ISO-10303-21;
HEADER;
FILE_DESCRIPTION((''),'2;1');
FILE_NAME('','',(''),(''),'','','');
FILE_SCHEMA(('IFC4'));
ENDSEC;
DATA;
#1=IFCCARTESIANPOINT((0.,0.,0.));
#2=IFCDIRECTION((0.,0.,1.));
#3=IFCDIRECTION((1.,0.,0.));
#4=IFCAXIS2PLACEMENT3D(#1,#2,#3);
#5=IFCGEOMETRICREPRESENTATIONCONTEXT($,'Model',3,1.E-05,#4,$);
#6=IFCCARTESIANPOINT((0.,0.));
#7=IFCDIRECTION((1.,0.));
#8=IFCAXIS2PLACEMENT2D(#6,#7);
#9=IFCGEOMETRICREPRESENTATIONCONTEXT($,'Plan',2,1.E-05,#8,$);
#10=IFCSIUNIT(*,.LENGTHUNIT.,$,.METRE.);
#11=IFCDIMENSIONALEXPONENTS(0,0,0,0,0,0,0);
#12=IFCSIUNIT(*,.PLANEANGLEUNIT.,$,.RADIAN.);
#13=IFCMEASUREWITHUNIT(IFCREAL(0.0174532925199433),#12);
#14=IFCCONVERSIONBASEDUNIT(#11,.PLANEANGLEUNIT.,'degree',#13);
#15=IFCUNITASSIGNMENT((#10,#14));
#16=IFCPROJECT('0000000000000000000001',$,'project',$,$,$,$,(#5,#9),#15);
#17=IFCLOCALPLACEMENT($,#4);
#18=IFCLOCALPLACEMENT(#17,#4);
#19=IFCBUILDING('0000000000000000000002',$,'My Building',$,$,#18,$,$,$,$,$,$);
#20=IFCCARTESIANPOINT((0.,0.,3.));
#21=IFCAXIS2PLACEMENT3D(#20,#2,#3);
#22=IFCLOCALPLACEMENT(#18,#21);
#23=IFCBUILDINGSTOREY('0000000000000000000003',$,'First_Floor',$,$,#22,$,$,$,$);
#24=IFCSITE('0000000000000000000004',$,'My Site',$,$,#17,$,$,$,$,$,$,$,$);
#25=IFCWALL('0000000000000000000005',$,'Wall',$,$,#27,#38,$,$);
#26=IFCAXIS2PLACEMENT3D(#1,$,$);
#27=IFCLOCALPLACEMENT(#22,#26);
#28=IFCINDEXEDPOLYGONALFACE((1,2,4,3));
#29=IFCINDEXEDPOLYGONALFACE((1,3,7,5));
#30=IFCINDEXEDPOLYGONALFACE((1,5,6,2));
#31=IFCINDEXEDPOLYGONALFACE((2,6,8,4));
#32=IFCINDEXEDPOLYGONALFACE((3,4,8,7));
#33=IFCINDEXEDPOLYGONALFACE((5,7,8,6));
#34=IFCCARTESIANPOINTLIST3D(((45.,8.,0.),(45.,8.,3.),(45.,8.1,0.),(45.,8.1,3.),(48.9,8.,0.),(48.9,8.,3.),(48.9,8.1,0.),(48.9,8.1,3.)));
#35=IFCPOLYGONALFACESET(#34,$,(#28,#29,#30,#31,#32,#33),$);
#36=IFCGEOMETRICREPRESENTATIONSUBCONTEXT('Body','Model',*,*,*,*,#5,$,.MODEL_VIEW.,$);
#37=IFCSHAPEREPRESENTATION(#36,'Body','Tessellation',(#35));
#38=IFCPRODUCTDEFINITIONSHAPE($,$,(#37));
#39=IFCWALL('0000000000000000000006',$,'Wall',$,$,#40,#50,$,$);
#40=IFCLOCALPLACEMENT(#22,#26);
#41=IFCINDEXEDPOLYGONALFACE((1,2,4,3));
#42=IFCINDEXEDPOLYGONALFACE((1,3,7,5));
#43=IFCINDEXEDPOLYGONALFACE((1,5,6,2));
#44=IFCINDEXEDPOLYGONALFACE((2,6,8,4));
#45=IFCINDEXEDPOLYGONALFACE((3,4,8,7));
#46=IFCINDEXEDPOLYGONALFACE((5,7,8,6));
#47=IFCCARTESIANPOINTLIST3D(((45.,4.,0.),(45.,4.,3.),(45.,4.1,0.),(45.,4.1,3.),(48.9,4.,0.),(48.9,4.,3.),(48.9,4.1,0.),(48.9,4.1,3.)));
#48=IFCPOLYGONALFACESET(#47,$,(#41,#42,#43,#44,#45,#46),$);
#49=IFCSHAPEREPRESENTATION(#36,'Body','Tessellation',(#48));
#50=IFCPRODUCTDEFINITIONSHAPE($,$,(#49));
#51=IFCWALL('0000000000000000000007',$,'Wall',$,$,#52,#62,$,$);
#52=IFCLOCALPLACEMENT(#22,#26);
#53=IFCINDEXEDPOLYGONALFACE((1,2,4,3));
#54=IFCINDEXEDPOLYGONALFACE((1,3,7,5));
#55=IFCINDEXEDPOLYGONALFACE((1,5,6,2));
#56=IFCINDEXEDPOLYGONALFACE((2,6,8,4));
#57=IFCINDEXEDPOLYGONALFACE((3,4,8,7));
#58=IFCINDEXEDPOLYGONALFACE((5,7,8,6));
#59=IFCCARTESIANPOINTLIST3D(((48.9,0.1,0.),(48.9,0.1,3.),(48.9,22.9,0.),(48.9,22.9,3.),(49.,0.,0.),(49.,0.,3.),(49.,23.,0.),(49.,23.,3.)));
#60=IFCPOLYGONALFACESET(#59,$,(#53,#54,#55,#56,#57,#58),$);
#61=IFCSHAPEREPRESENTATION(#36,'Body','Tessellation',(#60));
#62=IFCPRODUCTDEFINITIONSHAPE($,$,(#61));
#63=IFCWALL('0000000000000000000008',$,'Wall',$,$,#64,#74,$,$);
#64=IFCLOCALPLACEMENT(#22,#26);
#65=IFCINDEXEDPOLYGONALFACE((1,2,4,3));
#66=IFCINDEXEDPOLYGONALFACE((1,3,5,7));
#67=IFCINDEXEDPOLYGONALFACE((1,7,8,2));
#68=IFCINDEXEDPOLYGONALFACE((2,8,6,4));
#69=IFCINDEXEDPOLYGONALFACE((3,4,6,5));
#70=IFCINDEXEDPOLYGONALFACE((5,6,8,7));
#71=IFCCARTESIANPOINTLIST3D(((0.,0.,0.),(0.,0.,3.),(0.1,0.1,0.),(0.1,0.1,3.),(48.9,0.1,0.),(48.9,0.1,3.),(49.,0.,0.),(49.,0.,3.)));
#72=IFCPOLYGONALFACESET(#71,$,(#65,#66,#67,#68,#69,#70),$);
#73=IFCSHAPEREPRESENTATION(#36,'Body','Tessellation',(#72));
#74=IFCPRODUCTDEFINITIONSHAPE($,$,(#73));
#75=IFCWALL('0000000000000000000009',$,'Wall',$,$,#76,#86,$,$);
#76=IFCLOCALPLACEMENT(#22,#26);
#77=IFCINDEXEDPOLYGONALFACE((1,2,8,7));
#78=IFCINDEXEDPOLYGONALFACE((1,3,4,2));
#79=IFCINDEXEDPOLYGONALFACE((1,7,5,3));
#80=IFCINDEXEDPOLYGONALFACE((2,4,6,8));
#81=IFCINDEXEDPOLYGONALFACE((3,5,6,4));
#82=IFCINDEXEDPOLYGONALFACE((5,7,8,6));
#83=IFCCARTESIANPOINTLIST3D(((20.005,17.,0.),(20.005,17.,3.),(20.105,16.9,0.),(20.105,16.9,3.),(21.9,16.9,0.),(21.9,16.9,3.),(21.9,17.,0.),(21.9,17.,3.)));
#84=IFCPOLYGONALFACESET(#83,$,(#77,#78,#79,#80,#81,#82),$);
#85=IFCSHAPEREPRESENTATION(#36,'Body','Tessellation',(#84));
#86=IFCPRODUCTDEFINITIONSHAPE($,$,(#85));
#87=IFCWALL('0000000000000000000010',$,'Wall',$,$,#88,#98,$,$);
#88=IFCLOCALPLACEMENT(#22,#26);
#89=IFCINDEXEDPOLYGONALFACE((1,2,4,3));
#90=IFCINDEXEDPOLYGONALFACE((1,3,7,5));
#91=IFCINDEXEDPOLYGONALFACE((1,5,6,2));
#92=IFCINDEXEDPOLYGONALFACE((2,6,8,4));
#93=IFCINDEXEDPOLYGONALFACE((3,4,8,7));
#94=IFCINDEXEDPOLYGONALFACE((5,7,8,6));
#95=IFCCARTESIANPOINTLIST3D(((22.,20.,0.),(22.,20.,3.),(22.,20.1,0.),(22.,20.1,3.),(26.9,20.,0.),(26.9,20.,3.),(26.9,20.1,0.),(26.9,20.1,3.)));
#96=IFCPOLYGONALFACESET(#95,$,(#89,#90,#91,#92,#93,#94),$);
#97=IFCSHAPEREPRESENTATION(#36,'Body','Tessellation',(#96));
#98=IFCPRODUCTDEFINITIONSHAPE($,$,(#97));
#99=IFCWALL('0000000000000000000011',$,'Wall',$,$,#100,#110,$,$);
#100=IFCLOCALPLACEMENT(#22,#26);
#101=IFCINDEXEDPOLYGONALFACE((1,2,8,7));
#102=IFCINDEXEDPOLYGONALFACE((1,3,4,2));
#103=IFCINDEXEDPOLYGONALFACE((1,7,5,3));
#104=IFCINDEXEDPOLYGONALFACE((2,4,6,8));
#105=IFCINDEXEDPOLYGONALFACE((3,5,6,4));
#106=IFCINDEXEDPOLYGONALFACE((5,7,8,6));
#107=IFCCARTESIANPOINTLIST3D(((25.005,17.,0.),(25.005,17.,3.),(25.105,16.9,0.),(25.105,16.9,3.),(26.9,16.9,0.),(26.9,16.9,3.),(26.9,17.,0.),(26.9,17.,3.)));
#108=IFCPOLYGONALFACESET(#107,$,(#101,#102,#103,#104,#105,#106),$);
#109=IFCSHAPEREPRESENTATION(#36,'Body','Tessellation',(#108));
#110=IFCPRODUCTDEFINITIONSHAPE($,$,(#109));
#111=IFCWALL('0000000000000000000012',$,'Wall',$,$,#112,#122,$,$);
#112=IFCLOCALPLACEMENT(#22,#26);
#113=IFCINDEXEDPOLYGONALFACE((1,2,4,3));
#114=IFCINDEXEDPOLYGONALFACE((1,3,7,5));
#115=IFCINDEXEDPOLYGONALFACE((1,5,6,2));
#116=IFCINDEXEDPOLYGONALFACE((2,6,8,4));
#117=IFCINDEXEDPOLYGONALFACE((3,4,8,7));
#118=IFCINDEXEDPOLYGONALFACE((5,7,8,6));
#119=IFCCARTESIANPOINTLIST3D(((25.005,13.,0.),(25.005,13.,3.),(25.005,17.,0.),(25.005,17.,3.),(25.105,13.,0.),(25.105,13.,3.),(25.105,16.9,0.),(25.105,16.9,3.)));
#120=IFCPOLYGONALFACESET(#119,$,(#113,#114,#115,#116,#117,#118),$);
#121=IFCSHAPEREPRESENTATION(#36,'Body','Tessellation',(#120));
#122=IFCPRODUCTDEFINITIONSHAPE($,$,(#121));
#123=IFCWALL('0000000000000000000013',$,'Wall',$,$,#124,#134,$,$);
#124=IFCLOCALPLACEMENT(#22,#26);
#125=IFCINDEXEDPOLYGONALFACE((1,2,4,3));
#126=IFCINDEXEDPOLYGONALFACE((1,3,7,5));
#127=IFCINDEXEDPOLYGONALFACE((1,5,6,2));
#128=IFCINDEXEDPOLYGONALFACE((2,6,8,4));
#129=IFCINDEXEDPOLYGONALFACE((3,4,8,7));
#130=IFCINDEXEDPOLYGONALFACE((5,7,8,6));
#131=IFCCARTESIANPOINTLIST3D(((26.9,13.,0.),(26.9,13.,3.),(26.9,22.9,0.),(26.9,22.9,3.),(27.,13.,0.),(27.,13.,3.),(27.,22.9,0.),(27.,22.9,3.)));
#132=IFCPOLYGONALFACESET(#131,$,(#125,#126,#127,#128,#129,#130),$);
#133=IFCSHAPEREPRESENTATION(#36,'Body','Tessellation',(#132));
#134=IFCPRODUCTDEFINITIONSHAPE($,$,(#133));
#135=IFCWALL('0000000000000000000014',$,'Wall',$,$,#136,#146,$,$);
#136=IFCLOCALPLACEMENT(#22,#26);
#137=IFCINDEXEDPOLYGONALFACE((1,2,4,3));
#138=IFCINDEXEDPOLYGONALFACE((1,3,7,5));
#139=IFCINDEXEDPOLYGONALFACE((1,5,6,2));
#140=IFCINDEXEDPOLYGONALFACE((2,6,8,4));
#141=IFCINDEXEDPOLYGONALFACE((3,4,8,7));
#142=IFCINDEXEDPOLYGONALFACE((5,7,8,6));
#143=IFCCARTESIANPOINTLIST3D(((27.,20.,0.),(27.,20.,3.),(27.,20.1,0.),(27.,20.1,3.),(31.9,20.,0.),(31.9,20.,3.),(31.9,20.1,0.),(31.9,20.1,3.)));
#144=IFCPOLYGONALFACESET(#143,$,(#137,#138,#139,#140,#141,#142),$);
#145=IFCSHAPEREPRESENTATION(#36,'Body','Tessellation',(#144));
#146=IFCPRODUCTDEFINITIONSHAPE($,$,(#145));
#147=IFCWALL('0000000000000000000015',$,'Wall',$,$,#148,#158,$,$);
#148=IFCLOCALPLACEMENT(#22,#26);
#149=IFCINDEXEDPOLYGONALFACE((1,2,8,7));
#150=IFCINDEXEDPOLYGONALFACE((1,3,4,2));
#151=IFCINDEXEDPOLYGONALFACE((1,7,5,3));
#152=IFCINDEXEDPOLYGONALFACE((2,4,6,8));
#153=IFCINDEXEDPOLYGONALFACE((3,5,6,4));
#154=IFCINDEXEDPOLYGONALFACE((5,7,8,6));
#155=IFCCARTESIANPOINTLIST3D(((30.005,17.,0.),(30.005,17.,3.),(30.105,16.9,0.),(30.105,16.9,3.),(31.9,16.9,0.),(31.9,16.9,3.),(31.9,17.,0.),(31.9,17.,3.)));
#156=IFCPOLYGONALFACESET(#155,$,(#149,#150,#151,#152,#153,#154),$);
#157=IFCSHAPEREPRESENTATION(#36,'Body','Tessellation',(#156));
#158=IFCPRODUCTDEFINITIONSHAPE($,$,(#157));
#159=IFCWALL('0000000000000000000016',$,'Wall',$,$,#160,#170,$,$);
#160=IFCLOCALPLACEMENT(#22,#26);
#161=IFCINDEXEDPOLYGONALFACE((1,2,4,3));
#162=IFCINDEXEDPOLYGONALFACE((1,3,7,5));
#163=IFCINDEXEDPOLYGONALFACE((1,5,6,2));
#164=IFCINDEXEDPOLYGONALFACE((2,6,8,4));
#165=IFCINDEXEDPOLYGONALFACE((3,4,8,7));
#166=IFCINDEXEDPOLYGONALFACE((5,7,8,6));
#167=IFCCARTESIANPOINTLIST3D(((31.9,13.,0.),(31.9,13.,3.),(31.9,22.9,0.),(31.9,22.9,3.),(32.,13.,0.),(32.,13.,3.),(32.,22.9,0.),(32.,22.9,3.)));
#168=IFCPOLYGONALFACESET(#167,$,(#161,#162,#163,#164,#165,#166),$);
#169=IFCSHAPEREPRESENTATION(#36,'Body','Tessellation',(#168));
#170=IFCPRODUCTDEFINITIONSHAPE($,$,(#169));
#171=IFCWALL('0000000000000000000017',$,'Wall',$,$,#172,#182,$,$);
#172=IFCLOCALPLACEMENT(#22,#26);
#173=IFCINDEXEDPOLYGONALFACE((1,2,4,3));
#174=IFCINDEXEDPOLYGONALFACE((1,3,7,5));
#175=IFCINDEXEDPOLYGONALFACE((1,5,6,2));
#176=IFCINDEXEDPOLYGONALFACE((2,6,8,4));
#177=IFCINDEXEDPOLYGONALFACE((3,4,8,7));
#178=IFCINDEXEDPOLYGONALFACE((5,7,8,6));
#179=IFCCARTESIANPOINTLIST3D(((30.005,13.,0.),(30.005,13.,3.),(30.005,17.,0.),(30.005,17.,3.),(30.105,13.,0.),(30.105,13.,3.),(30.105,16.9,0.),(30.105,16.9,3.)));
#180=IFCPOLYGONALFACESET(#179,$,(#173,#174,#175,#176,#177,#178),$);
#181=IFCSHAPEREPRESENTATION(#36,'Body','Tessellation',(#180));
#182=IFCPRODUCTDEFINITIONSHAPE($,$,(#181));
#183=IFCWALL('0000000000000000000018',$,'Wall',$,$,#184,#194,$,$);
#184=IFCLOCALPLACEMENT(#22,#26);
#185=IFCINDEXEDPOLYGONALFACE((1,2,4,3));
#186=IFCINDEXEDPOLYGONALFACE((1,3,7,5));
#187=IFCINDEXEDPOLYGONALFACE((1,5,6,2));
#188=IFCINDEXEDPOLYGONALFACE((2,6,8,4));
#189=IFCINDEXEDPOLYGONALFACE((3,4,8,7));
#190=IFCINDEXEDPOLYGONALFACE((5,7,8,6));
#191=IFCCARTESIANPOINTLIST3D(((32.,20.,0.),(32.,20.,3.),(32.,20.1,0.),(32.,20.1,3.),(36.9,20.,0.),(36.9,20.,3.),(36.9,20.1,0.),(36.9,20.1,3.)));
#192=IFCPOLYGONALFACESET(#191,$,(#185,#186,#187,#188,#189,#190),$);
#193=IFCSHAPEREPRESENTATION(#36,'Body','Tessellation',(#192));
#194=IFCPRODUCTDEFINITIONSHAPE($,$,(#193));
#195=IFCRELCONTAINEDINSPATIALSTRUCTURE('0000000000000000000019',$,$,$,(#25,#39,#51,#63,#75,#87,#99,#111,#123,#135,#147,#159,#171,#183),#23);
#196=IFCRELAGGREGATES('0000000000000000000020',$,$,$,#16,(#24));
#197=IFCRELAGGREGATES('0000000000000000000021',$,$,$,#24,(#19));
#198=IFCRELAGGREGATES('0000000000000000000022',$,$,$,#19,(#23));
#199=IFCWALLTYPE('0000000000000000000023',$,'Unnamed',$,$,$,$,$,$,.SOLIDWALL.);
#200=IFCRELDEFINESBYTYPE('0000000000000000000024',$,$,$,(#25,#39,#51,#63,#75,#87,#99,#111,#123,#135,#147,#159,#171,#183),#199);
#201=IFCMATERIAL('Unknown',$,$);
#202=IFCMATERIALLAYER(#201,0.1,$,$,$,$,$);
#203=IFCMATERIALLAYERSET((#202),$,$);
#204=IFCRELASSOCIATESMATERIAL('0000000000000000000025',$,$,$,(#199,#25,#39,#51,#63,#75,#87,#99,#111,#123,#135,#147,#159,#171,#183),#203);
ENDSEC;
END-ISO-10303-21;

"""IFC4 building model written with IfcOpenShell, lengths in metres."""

from ifc_helpers import new_model, entity, si_unit, converted_unit, frame, origin_with_axes, origin_2d_with_axis, place, context, subcontext, project, spatial, line, indexed_curve, outline, extrude, material, layer, layer_set, layer_usage, type_object, element, save


model = new_model("IFC4")

# Units and contexts
model_context = context("Model", 3, precision=1e-05, world=origin_with_axes())
plan_context = context("Plan", 2, precision=1e-05, world=origin_2d_with_axis())
body_context = subcontext(model_context, "Body", "Model", "MODEL_VIEW")
ifc_project = project(units=[si_unit("LENGTHUNIT", "METRE"), converted_unit("PLANEANGLEUNIT", "degree", entity("IfcReal", 0.0174532925199433), si_unit("PLANEANGLEUNIT", "RADIAN"), dimensions=[0, 0, 0, 0, 0, 0, 0])], contexts=[model_context, plan_context])

# Site, building, storey
site_placement = place(None, origin_with_axes())
site = spatial("IfcSite", under=ifc_project, at=site_placement, Name="My Site")
building_placement = place(site_placement, origin_with_axes())
building = spatial("IfcBuilding", under=site, at=building_placement, Name="My Building")
storey_placement = place(building_placement, frame((0.0, 0.0, 3.0), z_axis=(0.0, 0.0, 1.0), x_axis=(1.0, 0.0, 0.0)))
storey = spatial("IfcBuildingStorey", under=building, at=storey_placement, Name="First_Floor")

# Walls
ifc_material = material(Name="Unknown")
ifc_layer = layer(ifc_material, 0.1)
ifc_layer_set = layer_set([ifc_layer])
wall_type = type_object("IfcWallType", Name="Unnamed", PredefinedType="SOLIDWALL", material=ifc_layer_set)
ifc_layer_usage_1 = layer_usage(ifc_layer_set, "AXIS2", "POSITIVE", 0.0)
wall_1_placement = place(storey_placement, frame((45.0, 8.0, 0.0), z_axis=(0.0, 0.0, 1.0), x_axis=(1.0, 0.0, 0.0)))
element("IfcWall", 1, at=wall_1_placement, inside=storey, type_object=wall_type, material=ifc_layer_usage_1, Name="Wall", context=body_context, shape_type="SweptSolid", body=[
    extrude(outline(indexed_curve([(0.0, 0.0), (0.0, 0.1), (3.9, 0.1), (3.9, 0.0)], segments=[line(1, 2, 3, 4, 1)])), origin_with_axes(), (0.0, 0.0, 1.0), 3.0),
])
ifc_layer_usage_2 = layer_usage(ifc_layer_set, "AXIS2", "POSITIVE", 0.0)
wall_2_placement = place(storey_placement, frame((45.0, 4.0, 0.0), z_axis=(0.0, 0.0, 1.0), x_axis=(1.0, 0.0, 0.0)))
element("IfcWall", 2, at=wall_2_placement, inside=storey, type_object=wall_type, material=ifc_layer_usage_2, Name="Wall", context=body_context, shape_type="SweptSolid", body=[
    extrude(outline(indexed_curve([(0.0, 0.0), (0.0, 0.1), (3.9, 0.1), (3.9, 0.0)], segments=[line(1, 2, 3, 4, 1)])), origin_with_axes(), (0.0, 0.0, 1.0), 3.0),
])
ifc_layer_usage_3 = layer_usage(ifc_layer_set, "AXIS2", "POSITIVE", 0.0)
wall_3_placement = place(storey_placement, frame((48.9, 22.9, 0.0), z_axis=(0.0, 0.0, 1.0), x_axis=(0.0, -1.0, 0.0)))
element("IfcWall", 3, at=wall_3_placement, inside=storey, type_object=wall_type, material=ifc_layer_usage_3, Name="Wall", context=body_context, shape_type="SweptSolid", body=[
    extrude(outline(indexed_curve([(0.0, 0.0), (-0.1, 0.1), (22.9, 0.1), (22.8, 0.0)], segments=[line(1, 2, 3, 4, 1)])), origin_with_axes(), (0.0, 0.0, 1.0), 3.0),
])
ifc_layer_usage_4 = layer_usage(ifc_layer_set, "AXIS2", "POSITIVE", 0.0)
wall_4_placement = place(storey_placement, frame((48.9, 0.1, 0.0), z_axis=(0.0, 0.0, 1.0), x_axis=(-1.0, 0.0, 0.0)))
element("IfcWall", 4, at=wall_4_placement, inside=storey, type_object=wall_type, material=ifc_layer_usage_4, Name="Wall", context=body_context, shape_type="SweptSolid", body=[
    extrude(outline(indexed_curve([(0.0, 0.0), (-0.1, 0.1), (48.9, 0.1), (48.8, 0.0)], segments=[line(1, 2, 3, 4, 1)])), origin_with_axes(), (0.0, 0.0, 1.0), 3.0),
])
ifc_layer_usage_5 = layer_usage(ifc_layer_set, "AXIS2", "POSITIVE", 0.0)
wall_5_placement = place(storey_placement, frame((21.9, 17.0, 0.0), z_axis=(0.0, 0.0, 1.0), x_axis=(-1.0, 0.0, 0.0)))
element("IfcWall", 5, at=wall_5_placement, inside=storey, type_object=wall_type, material=ifc_layer_usage_5, Name="Wall", context=body_context, shape_type="SweptSolid", body=[
    extrude(outline(indexed_curve([(0.0, 0.0), (0.0, 0.1), (1.795, 0.1), (1.895, 0.0)], segments=[line(1, 2, 3, 4, 1)])), origin_with_axes(), (0.0, 0.0, 1.0), 3.0),
])
ifc_layer_usage_6 = layer_usage(ifc_layer_set, "AXIS2", "POSITIVE", 0.0)
wall_6_placement = place(storey_placement, frame((22.0, 20.0, 0.0), z_axis=(0.0, 0.0, 1.0), x_axis=(1.0, 0.0, 0.0)))
element("IfcWall", 6, at=wall_6_placement, inside=storey, type_object=wall_type, material=ifc_layer_usage_6, Name="Wall", context=body_context, shape_type="SweptSolid", body=[
    extrude(outline(indexed_curve([(0.0, 0.0), (0.0, 0.1), (4.9, 0.1), (4.9, 0.0)], segments=[line(1, 2, 3, 4, 1)])), origin_with_axes(), (0.0, 0.0, 1.0), 3.0),
])
ifc_layer_usage_7 = layer_usage(ifc_layer_set, "AXIS2", "POSITIVE", 0.0)
wall_7_placement = place(storey_placement, frame((26.9, 17.0, 0.0), z_axis=(0.0, 0.0, 1.0), x_axis=(-1.0, 0.0, 0.0)))
element("IfcWall", 7, at=wall_7_placement, inside=storey, type_object=wall_type, material=ifc_layer_usage_7, Name="Wall", context=body_context, shape_type="SweptSolid", body=[
    extrude(outline(indexed_curve([(0.0, 0.0), (0.0, 0.1), (1.795, 0.1), (1.895, 0.0)], segments=[line(1, 2, 3, 4, 1)])), origin_with_axes(), (0.0, 0.0, 1.0), 3.0),
])
ifc_layer_usage_8 = layer_usage(ifc_layer_set, "AXIS2", "POSITIVE", 0.0)
wall_8_placement = place(storey_placement, frame((25.005, 17.0, 0.0), z_axis=(0.0, 0.0, 1.0), x_axis=(0.0, -1.0, 0.0)))
element("IfcWall", 8, at=wall_8_placement, inside=storey, type_object=wall_type, material=ifc_layer_usage_8, Name="Wall", context=body_context, shape_type="SweptSolid", body=[
    extrude(outline(indexed_curve([(0.0, 0.0), (0.1, 0.1), (4.0, 0.1), (4.0, 0.0)], segments=[line(1, 2, 3, 4, 1)])), origin_with_axes(), (0.0, 0.0, 1.0), 3.0),
])
ifc_layer_usage_9 = layer_usage(ifc_layer_set, "AXIS2", "POSITIVE", 0.0)
wall_9_placement = place(storey_placement, frame((26.9, 22.9, 0.0), z_axis=(0.0, 0.0, 1.0), x_axis=(0.0, -1.0, 0.0)))
element("IfcWall", 9, at=wall_9_placement, inside=storey, type_object=wall_type, material=ifc_layer_usage_9, Name="Wall", context=body_context, shape_type="SweptSolid", body=[
    extrude(outline(indexed_curve([(0.0, 0.0), (0.0, 0.1), (9.9, 0.1), (9.9, 0.0)], segments=[line(1, 2, 3, 4, 1)])), origin_with_axes(), (0.0, 0.0, 1.0), 3.0),
])
ifc_layer_usage_10 = layer_usage(ifc_layer_set, "AXIS2", "POSITIVE", 0.0)
wall_10_placement = place(storey_placement, frame((27.0, 20.0, 0.0), z_axis=(0.0, 0.0, 1.0), x_axis=(1.0, 0.0, 0.0)))
element("IfcWall", 10, at=wall_10_placement, inside=storey, type_object=wall_type, material=ifc_layer_usage_10, Name="Wall", context=body_context, shape_type="SweptSolid", body=[
    extrude(outline(indexed_curve([(0.0, 0.0), (0.0, 0.1), (4.9, 0.1), (4.9, 0.0)], segments=[line(1, 2, 3, 4, 1)])), origin_with_axes(), (0.0, 0.0, 1.0), 3.0),
])
ifc_layer_usage_11 = layer_usage(ifc_layer_set, "AXIS2", "POSITIVE", 0.0)
wall_11_placement = place(storey_placement, frame((31.9, 17.0, 0.0), z_axis=(0.0, 0.0, 1.0), x_axis=(-1.0, 0.0, 0.0)))
element("IfcWall", 11, at=wall_11_placement, inside=storey, type_object=wall_type, material=ifc_layer_usage_11, Name="Wall", context=body_context, shape_type="SweptSolid", body=[
    extrude(outline(indexed_curve([(0.0, 0.0), (0.0, 0.1), (1.795, 0.1), (1.895, 0.0)], segments=[line(1, 2, 3, 4, 1)])), origin_with_axes(), (0.0, 0.0, 1.0), 3.0),
])
ifc_layer_usage_12 = layer_usage(ifc_layer_set, "AXIS2", "POSITIVE", 0.0)
wall_12_placement = place(storey_placement, frame((31.9, 22.9, 0.0), z_axis=(0.0, 0.0, 1.0), x_axis=(0.0, -1.0, 0.0)))
element("IfcWall", 12, at=wall_12_placement, inside=storey, type_object=wall_type, material=ifc_layer_usage_12, Name="Wall", context=body_context, shape_type="SweptSolid", body=[
    extrude(outline(indexed_curve([(0.0, 0.0), (0.0, 0.1), (9.9, 0.1), (9.9, 0.0)], segments=[line(1, 2, 3, 4, 1)])), origin_with_axes(), (0.0, 0.0, 1.0), 3.0),
])
ifc_layer_usage_13 = layer_usage(ifc_layer_set, "AXIS2", "POSITIVE", 0.0)
wall_13_placement = place(storey_placement, frame((30.005, 17.0, 0.0), z_axis=(0.0, 0.0, 1.0), x_axis=(0.0, -1.0, 0.0)))
element("IfcWall", 13, at=wall_13_placement, inside=storey, type_object=wall_type, material=ifc_layer_usage_13, Name="Wall", context=body_context, shape_type="SweptSolid", body=[
    extrude(outline(indexed_curve([(0.0, 0.0), (0.1, 0.1), (4.0, 0.1), (4.0, 0.0)], segments=[line(1, 2, 3, 4, 1)])), origin_with_axes(), (0.0, 0.0, 1.0), 3.0),
])
ifc_layer_usage_14 = layer_usage(ifc_layer_set, "AXIS2", "POSITIVE", 0.0)
wall_14_placement = place(storey_placement, frame((32.0, 20.0, 0.0), z_axis=(0.0, 0.0, 1.0), x_axis=(1.0, 0.0, 0.0)))
element("IfcWall", 14, at=wall_14_placement, inside=storey, type_object=wall_type, material=ifc_layer_usage_14, Name="Wall", context=body_context, shape_type="SweptSolid", body=[
    extrude(outline(indexed_curve([(0.0, 0.0), (0.0, 0.1), (4.9, 0.1), (4.9, 0.0)], segments=[line(1, 2, 3, 4, 1)])), origin_with_axes(), (0.0, 0.0, 1.0), 3.0),
])

save(model, "model.ifc")
